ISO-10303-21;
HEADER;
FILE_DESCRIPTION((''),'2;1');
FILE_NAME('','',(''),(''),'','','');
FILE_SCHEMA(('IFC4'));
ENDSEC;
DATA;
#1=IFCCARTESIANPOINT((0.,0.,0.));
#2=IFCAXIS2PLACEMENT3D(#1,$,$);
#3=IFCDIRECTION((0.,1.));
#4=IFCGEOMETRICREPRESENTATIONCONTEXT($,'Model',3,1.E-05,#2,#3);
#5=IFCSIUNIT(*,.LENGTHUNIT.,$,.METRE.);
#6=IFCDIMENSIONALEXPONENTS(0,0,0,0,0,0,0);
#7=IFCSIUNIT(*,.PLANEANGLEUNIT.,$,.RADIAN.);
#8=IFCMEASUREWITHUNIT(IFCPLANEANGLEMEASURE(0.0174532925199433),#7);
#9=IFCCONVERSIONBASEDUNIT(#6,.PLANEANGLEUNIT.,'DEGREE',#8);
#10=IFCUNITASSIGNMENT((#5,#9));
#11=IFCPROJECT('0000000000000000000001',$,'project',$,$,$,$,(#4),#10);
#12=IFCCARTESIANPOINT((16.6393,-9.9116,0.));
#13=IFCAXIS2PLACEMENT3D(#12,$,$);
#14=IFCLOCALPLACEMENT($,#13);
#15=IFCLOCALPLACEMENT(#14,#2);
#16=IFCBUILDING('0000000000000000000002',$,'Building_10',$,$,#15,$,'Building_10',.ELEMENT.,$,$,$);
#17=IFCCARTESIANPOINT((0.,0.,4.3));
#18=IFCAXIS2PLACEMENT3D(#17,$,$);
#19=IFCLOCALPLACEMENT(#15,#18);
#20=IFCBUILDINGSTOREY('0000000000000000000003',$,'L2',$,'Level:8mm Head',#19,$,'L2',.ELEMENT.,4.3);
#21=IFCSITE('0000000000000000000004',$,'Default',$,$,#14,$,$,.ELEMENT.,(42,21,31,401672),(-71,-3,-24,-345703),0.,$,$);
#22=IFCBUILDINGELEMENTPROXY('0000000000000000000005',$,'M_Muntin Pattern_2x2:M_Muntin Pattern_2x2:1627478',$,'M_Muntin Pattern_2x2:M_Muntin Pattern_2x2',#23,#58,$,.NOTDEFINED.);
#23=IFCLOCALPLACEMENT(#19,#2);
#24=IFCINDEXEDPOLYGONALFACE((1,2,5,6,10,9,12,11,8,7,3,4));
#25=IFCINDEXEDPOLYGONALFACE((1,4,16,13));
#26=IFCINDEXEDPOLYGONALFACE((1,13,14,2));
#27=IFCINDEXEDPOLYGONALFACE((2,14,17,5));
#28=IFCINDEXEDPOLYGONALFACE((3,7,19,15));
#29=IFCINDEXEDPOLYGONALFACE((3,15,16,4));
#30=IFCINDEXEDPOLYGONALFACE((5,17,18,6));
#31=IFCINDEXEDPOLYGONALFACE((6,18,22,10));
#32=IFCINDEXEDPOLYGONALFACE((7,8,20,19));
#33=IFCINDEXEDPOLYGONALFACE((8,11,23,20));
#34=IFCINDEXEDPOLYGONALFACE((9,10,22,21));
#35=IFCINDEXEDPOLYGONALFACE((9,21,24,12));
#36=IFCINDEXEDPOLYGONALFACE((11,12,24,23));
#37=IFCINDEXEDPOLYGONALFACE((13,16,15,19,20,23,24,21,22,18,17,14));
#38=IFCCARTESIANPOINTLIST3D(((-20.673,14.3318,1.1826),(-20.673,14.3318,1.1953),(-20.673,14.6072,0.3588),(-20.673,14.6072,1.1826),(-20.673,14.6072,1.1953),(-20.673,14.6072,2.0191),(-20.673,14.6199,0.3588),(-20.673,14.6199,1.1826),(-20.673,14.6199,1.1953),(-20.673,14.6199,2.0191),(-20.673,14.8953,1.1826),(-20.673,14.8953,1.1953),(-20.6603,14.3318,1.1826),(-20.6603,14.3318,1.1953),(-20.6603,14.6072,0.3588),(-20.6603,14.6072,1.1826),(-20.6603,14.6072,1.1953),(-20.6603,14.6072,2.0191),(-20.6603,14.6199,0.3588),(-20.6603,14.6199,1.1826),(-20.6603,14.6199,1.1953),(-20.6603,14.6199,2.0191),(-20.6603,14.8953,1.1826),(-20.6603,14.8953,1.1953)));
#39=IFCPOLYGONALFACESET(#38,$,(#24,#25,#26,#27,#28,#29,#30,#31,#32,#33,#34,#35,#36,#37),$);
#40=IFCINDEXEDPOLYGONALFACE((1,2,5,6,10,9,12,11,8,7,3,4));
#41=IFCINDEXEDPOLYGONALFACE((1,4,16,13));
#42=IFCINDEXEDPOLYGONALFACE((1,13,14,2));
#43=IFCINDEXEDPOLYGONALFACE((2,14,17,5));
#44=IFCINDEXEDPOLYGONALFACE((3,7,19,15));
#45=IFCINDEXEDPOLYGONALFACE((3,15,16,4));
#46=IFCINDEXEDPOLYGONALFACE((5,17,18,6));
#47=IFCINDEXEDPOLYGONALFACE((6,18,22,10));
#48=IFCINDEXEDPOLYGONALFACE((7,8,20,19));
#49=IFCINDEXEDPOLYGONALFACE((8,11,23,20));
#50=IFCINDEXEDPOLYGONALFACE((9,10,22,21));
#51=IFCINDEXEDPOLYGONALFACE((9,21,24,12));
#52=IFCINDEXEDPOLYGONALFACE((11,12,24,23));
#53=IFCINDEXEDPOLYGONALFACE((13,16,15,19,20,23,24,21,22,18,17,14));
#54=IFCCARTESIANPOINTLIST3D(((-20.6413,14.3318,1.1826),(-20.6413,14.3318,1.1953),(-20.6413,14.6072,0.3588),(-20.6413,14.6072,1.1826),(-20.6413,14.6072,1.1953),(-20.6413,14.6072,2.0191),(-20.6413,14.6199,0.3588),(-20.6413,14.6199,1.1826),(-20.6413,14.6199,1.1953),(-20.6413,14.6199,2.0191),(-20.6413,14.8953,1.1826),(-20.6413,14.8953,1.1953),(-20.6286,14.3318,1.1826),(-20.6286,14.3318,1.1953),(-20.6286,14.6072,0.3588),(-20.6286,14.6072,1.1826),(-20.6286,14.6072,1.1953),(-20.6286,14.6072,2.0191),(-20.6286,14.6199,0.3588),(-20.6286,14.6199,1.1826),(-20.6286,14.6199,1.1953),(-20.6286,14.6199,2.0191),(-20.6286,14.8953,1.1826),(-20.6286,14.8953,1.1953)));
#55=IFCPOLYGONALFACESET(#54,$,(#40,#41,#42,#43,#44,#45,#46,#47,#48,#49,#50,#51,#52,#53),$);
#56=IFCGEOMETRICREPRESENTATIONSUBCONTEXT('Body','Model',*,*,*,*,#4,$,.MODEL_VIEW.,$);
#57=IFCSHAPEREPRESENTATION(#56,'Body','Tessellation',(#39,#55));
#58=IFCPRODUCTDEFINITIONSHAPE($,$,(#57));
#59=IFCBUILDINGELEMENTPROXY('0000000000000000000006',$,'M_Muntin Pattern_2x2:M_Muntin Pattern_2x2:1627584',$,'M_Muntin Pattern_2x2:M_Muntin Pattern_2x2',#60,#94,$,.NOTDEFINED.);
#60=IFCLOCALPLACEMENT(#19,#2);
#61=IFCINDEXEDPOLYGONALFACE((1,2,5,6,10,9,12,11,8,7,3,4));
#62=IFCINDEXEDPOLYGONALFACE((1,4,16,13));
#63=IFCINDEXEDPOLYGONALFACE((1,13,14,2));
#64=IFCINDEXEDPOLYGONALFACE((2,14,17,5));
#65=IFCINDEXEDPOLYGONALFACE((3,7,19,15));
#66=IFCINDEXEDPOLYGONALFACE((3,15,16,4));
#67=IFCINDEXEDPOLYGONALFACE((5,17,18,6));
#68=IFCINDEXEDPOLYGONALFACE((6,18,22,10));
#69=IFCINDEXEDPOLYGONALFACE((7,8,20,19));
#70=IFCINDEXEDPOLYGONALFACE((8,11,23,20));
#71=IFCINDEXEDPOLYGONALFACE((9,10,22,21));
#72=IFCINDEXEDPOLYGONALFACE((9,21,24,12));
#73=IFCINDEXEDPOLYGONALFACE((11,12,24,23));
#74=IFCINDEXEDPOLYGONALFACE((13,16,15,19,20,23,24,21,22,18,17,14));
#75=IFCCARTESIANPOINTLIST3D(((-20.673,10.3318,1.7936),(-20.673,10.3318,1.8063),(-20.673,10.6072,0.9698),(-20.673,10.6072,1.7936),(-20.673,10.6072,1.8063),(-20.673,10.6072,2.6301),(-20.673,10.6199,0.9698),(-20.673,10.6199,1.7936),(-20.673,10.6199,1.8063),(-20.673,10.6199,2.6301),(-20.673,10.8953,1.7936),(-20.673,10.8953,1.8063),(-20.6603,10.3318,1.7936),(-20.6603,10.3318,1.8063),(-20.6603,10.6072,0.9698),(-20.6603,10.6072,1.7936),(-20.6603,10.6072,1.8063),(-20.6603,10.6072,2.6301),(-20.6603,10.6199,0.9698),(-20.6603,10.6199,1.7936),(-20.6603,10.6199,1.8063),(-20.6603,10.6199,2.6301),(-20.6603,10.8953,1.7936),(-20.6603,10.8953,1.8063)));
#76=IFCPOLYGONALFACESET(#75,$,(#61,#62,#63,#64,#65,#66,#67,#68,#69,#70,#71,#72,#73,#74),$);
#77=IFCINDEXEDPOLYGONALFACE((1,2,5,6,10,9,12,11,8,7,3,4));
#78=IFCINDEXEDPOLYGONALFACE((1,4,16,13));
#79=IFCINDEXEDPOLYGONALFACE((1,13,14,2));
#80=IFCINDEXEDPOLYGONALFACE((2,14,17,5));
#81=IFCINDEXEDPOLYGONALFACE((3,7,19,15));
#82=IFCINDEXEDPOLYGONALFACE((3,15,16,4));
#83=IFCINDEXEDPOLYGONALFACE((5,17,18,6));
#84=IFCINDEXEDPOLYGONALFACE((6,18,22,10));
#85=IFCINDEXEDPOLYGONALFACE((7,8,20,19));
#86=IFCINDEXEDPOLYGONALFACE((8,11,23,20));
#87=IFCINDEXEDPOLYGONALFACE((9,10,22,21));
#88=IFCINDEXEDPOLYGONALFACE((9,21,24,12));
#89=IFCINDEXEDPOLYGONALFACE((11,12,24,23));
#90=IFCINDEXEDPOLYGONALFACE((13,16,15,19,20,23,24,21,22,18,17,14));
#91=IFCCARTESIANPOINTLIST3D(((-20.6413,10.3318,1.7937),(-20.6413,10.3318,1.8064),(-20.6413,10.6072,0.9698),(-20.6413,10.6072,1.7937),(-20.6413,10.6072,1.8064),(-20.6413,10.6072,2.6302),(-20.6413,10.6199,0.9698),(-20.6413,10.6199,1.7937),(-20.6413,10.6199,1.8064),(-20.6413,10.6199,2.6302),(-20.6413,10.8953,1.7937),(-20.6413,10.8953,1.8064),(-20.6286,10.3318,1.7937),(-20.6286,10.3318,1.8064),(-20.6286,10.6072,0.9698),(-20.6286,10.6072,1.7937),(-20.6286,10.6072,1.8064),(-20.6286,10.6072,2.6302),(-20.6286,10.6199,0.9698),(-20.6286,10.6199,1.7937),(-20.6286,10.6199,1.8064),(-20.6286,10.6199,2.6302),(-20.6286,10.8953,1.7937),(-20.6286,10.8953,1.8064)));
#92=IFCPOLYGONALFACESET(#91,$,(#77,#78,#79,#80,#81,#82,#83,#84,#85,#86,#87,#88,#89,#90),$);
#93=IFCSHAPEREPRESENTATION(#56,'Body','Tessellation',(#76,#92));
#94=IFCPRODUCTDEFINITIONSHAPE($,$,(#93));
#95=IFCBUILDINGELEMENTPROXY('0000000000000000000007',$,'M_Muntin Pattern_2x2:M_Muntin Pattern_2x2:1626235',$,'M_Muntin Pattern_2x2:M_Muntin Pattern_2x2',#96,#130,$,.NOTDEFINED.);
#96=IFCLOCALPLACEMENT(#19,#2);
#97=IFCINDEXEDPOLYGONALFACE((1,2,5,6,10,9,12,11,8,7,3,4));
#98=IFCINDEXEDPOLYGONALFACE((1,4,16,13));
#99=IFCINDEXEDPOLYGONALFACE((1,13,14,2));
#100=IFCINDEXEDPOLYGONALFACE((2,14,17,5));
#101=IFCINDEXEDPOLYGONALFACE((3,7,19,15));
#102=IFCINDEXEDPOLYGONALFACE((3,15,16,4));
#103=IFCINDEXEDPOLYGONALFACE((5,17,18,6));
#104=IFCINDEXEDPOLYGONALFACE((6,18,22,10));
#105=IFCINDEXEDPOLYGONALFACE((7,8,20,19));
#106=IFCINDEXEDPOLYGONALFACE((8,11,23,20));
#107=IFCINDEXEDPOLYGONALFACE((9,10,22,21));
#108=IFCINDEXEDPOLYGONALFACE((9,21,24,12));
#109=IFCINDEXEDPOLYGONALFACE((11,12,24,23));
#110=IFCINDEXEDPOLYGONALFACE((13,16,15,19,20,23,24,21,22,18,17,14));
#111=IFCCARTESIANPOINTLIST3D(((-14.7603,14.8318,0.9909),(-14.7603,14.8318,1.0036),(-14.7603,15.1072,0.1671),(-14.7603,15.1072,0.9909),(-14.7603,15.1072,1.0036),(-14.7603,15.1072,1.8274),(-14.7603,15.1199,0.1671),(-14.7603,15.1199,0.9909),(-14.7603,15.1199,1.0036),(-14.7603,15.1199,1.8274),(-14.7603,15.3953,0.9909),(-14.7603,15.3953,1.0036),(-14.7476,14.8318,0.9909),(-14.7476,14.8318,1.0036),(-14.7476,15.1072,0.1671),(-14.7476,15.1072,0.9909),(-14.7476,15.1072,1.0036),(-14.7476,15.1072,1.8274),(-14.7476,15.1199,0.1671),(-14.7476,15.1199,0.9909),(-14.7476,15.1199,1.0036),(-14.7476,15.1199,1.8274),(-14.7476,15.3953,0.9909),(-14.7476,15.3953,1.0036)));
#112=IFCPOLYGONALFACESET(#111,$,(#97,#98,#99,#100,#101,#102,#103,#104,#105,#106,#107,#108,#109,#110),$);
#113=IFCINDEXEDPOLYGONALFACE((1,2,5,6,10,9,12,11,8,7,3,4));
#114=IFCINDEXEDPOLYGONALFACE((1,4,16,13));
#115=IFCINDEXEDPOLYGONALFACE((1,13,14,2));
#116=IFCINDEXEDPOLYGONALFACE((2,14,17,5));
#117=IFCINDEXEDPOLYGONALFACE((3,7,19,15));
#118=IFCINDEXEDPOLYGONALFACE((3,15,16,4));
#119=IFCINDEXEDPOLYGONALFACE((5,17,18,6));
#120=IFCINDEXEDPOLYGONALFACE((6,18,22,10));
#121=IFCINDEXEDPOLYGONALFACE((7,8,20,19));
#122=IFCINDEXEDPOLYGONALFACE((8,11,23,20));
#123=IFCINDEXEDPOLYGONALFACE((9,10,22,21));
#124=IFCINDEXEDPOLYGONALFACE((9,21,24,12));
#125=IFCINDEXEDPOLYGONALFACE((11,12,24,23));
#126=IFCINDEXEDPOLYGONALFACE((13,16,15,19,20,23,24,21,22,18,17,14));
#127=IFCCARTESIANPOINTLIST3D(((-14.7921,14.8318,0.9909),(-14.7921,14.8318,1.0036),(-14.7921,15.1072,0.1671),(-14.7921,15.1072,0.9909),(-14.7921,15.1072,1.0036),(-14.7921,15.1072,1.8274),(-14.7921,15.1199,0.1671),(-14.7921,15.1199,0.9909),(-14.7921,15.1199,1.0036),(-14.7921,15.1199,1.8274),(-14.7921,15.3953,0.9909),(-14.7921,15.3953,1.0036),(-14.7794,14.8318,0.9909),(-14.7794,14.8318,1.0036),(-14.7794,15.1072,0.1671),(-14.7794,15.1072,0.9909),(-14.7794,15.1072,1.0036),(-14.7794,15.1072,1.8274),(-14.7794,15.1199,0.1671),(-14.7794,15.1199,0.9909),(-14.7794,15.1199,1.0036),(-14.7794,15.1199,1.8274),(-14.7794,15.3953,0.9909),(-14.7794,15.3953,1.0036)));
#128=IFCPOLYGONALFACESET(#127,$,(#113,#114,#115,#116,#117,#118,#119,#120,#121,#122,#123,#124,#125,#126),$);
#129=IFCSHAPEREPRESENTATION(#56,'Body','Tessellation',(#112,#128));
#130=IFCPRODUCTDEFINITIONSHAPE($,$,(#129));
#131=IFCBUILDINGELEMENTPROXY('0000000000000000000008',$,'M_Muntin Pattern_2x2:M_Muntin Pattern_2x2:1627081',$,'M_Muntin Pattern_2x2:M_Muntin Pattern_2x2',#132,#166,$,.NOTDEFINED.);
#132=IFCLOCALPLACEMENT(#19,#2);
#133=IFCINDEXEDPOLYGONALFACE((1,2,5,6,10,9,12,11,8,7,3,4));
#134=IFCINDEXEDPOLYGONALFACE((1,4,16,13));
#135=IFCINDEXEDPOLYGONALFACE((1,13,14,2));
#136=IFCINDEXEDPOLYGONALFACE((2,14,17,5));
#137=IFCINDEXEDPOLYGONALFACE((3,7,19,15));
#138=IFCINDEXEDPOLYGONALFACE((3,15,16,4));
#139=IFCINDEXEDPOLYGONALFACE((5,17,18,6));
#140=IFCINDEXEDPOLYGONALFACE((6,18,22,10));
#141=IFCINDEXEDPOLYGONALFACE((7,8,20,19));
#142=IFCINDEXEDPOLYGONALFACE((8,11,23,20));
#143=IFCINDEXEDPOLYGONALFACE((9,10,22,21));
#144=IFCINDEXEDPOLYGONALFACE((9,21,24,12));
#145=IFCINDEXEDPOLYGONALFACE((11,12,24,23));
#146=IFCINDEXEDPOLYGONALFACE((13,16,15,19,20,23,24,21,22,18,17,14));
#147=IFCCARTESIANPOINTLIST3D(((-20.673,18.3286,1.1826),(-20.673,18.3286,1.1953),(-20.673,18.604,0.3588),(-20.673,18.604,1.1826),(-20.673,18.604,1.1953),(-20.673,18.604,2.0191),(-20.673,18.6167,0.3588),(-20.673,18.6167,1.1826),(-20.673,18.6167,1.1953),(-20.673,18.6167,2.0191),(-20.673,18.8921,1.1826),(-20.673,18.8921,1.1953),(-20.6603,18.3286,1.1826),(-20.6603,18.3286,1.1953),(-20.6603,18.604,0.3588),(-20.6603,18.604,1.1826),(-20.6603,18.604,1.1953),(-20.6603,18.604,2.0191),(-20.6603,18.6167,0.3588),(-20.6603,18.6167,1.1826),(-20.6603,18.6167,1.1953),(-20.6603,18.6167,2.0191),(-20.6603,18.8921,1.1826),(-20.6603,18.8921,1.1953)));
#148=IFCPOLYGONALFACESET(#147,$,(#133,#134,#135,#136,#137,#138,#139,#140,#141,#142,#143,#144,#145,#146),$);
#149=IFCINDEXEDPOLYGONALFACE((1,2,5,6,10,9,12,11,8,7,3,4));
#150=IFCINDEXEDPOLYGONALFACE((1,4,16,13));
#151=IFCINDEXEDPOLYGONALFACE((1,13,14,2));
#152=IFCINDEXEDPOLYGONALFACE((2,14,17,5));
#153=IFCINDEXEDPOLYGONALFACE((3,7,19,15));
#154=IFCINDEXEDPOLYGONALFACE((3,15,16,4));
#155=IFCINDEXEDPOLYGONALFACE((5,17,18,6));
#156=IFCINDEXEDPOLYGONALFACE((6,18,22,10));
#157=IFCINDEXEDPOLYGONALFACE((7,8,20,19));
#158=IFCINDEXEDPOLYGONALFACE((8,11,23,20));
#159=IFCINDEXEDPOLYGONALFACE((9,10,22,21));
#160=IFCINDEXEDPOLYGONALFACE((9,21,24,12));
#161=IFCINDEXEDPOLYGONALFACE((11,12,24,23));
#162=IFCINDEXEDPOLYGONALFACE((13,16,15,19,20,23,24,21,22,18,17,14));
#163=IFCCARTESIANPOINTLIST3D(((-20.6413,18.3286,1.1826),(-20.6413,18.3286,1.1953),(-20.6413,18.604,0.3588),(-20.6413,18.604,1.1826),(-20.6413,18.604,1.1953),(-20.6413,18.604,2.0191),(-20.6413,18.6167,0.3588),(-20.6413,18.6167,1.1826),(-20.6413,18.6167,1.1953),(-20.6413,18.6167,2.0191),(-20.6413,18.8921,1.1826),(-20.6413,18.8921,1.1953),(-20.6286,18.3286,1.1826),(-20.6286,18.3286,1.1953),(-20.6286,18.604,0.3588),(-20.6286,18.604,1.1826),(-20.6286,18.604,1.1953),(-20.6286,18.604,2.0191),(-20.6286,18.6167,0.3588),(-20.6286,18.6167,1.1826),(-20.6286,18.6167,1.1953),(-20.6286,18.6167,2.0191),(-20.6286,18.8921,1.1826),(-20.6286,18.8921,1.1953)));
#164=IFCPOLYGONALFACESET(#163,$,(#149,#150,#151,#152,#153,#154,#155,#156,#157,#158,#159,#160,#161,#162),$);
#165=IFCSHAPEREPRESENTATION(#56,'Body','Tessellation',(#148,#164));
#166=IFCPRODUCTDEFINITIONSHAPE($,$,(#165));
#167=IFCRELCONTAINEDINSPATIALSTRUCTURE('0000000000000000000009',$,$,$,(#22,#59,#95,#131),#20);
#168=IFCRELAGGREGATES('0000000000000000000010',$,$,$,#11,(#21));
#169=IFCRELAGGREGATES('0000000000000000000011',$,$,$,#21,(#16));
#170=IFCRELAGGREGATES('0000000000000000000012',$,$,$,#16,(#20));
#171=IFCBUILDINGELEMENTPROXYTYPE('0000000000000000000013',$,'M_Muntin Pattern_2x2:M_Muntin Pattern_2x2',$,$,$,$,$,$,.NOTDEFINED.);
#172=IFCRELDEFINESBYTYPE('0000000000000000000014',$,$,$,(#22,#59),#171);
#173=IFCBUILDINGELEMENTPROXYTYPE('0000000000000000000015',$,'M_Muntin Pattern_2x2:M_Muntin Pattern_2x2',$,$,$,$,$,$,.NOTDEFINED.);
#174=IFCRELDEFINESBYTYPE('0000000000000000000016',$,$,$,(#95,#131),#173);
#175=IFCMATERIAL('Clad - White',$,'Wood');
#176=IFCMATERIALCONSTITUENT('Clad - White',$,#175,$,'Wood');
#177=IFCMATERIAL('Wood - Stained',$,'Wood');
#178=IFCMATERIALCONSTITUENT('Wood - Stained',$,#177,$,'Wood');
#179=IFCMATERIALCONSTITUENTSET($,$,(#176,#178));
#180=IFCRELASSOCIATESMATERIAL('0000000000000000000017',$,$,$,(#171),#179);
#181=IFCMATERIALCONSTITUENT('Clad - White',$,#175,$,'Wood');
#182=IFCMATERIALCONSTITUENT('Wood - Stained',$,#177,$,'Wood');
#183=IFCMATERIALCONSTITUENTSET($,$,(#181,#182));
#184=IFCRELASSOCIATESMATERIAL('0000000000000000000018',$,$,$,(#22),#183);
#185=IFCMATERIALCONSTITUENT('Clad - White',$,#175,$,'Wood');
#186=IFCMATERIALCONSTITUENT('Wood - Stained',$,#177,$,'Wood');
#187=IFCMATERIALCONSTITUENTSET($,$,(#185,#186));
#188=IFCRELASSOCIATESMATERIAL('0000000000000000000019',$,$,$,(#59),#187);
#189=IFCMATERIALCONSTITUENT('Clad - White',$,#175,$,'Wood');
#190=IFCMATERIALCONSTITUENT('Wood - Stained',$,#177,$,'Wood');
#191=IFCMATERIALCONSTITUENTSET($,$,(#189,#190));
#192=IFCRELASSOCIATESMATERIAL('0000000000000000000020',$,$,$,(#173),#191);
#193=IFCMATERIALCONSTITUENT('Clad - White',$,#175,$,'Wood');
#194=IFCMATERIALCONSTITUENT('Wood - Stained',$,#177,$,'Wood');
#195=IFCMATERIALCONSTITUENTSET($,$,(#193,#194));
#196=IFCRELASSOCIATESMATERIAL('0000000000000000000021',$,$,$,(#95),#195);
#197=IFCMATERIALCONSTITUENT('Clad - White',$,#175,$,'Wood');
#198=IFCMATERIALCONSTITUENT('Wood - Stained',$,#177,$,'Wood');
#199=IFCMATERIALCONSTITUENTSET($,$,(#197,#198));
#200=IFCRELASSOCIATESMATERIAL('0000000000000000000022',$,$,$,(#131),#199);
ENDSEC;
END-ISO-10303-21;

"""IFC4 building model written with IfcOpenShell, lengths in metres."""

from ifc_helpers import new_model, entity, si_unit, converted_unit, direction, frame, origin, place, context, subcontext, project, spatial, indexed_curve, outline, extrude, source, transform, mapped, material, constituent, constituent_set, type_object, type_shapes, element, save


model = new_model("IFC4")

# Units and contexts
model_context = context("Model", 3, precision=1e-05, world=origin(), true_north=direction((0.0, 1.0)))
body_context = subcontext(model_context, "Body", "Model", "MODEL_VIEW")
ifc_project = project(units=[si_unit("LENGTHUNIT", "METRE"), converted_unit("PLANEANGLEUNIT", "DEGREE", entity("IfcPlaneAngleMeasure", 0.0174532925199433), si_unit("PLANEANGLEUNIT", "RADIAN"), dimensions=[0, 0, 0, 0, 0, 0, 0])], contexts=[model_context])

# Site, building, storey
site_placement = place(None, frame((16.6393, -9.9116, 0.0)))
site = spatial("IfcSite", under=ifc_project, at=site_placement, Name="Default", CompositionType="ELEMENT", RefLatitude=(42, 21, 31, 401672), RefLongitude=(-71, -3, -24, -345703), RefElevation=0.0)
building_placement = place(site_placement, origin())
building = spatial("IfcBuilding", under=site, at=building_placement, Name="Building_10", LongName="Building_10", CompositionType="ELEMENT")
storey_placement = place(building_placement, frame((0.0, 0.0, 4.3)))
storey = spatial("IfcBuildingStorey", under=building, at=storey_placement, Name="L2", ObjectType="Level:8mm Head", LongName="L2", CompositionType="ELEMENT", Elevation=4.3)

# Building element proxies
ifc_material_1 = material(Name="Clad - White", Category="Wood")
ifc_material_2 = material(Name="Wood - Stained", Category="Wood")
ifc_constituent_1 = constituent(ifc_material_1, Name="Clad - White", Category="Wood")
ifc_constituent_2 = constituent(ifc_material_2, Name="Wood - Stained", Category="Wood")
ifc_constituent_set_1 = constituent_set(constituents=[ifc_constituent_1, ifc_constituent_2])
building_element_proxy_type_1 = type_object("IfcBuildingElementProxyType", Name="M_Muntin Pattern_2x2:M_Muntin Pattern_2x2", PredefinedType="NOTDEFINED", material=ifc_constituent_set_1)
shared_shape_1 = source(origin(), body_context, "Body", "SweptSolid", [
    extrude(outline(indexed_curve([(0.0064, -0.0064), (0.8301, -0.0064), (0.8301, 0.0063), (0.0064, 0.0063), (0.0064, 0.2817), (-0.0063, 0.2817), (-0.0063, 0.0063), (-0.8302, 0.0063), (-0.8302, -0.0064), (-0.0063, -0.0064), (-0.0063, -0.2817), (0.0064, -0.2817), (0.0064, -0.0064)], self_intersect=False)), frame((0.0, 0.0095, 0.8301), z_axis=(0.0, 1.0, 0.0), x_axis=(0.0, 0.0, 1.0)), (0.0, 0.0, 1.0), 0.0127),
    extrude(outline(indexed_curve([(0.0064, -0.0064), (0.8302, -0.0064), (0.8302, 0.0063), (0.0064, 0.0063), (0.0064, 0.2817), (-0.0063, 0.2817), (-0.0063, 0.0063), (-0.8302, 0.0063), (-0.8302, -0.0064), (-0.0063, -0.0064), (-0.0063, -0.2817), (0.0064, -0.2817), (0.0064, -0.0064)], self_intersect=False)), frame((0.0, -0.0222, 0.8302), z_axis=(0.0, 1.0, 0.0), x_axis=(0.0, 0.0, 1.0)), (0.0, 0.0, 1.0), 0.0127),
])
type_shapes(building_element_proxy_type_1, [shared_shape_1])
ifc_constituent_3 = constituent(ifc_material_1, Name="Clad - White", Category="Wood")
ifc_constituent_4 = constituent(ifc_material_2, Name="Wood - Stained", Category="Wood")
ifc_constituent_set_2 = constituent_set(constituents=[ifc_constituent_3, ifc_constituent_4])
proxy_1_placement = place(storey_placement, frame((-20.6508, 14.6136, 0.3588), z_axis=(0.0, 0.0, 1.0), x_axis=(0.0, 1.0, 0.0)))
element("IfcBuildingElementProxy", 1, at=proxy_1_placement, inside=storey, type_object=building_element_proxy_type_1, material=ifc_constituent_set_2, Name="M_Muntin Pattern_2x2:M_Muntin Pattern_2x2:1627478", ObjectType="M_Muntin Pattern_2x2:M_Muntin Pattern_2x2", PredefinedType="NOTDEFINED", context=body_context, shape_type="MappedRepresentation", body=[
    mapped(shared_shape_1, transform((0.0, 0.0, 0.0), scale=1.0)),
])
ifc_constituent_5 = constituent(ifc_material_1, Name="Clad - White", Category="Wood")
ifc_constituent_6 = constituent(ifc_material_2, Name="Wood - Stained", Category="Wood")
ifc_constituent_set_3 = constituent_set(constituents=[ifc_constituent_5, ifc_constituent_6])
proxy_2_placement = place(storey_placement, frame((-20.6508, 10.6136, 0.9698), z_axis=(0.0, 0.0, 1.0), x_axis=(0.0, 1.0, 0.0)))
element("IfcBuildingElementProxy", 2, at=proxy_2_placement, inside=storey, type_object=building_element_proxy_type_1, material=ifc_constituent_set_3, Name="M_Muntin Pattern_2x2:M_Muntin Pattern_2x2:1627584", ObjectType="M_Muntin Pattern_2x2:M_Muntin Pattern_2x2", PredefinedType="NOTDEFINED", context=body_context, shape_type="MappedRepresentation", body=[
    mapped(shared_shape_1, transform((0.0, 0.0, 0.0), scale=1.0)),
])
ifc_constituent_7 = constituent(ifc_material_1, Name="Clad - White", Category="Wood")
ifc_constituent_8 = constituent(ifc_material_2, Name="Wood - Stained", Category="Wood")
ifc_constituent_set_4 = constituent_set(constituents=[ifc_constituent_7, ifc_constituent_8])
ifc_constituent_9 = constituent(ifc_material_1, Name="Clad - White", Category="Wood")
ifc_constituent_10 = constituent(ifc_material_2, Name="Wood - Stained", Category="Wood")
ifc_constituent_set_5 = constituent_set(constituents=[ifc_constituent_9, ifc_constituent_10])
building_element_proxy_type_2 = type_object("IfcBuildingElementProxyType", Name="M_Muntin Pattern_2x2:M_Muntin Pattern_2x2", PredefinedType="NOTDEFINED", material=ifc_constituent_set_5)
shared_shape_2 = source(origin(), body_context, "Body", "SweptSolid", [
    extrude(outline(indexed_curve([(0.0064, -0.0064), (0.8301, -0.0064), (0.8301, 0.0063), (0.0064, 0.0063), (0.0064, 0.2817), (-0.0063, 0.2817), (-0.0063, 0.0063), (-0.8302, 0.0063), (-0.8302, -0.0064), (-0.0063, -0.0064), (-0.0063, -0.2817), (0.0064, -0.2817), (0.0064, -0.0064)], self_intersect=False)), frame((0.0, -0.0222, 0.8301), z_axis=(0.0, 1.0, 0.0), x_axis=(0.0, 0.0, 1.0)), (0.0, 0.0, 1.0), 0.0127),
    extrude(outline(indexed_curve([(0.0064, -0.0064), (0.8302, -0.0064), (0.8302, 0.0063), (0.0064, 0.0063), (0.0064, 0.2817), (-0.0063, 0.2817), (-0.0063, 0.0063), (-0.8302, 0.0063), (-0.8302, -0.0064), (-0.0063, -0.0064), (-0.0063, -0.2817), (0.0064, -0.2817), (0.0064, -0.0064)], self_intersect=False)), frame((0.0, 0.0095, 0.8302), z_axis=(0.0, 1.0, 0.0), x_axis=(0.0, 0.0, 1.0)), (0.0, 0.0, 1.0), 0.0127),
])
type_shapes(building_element_proxy_type_2, [shared_shape_2])
proxy_3_placement = place(storey_placement, frame((-14.7698, 15.1136, 0.1671), z_axis=(0.0, 0.0, 1.0), x_axis=(0.0, 1.0, 0.0)))
element("IfcBuildingElementProxy", 3, at=proxy_3_placement, inside=storey, type_object=building_element_proxy_type_2, material=ifc_constituent_set_4, Name="M_Muntin Pattern_2x2:M_Muntin Pattern_2x2:1626235", ObjectType="M_Muntin Pattern_2x2:M_Muntin Pattern_2x2", PredefinedType="NOTDEFINED", context=body_context, shape_type="MappedRepresentation", body=[
    mapped(shared_shape_2, transform((0.0, 0.0, 0.0), scale=1.0)),
])
ifc_constituent_11 = constituent(ifc_material_1, Name="Clad - White", Category="Wood")
ifc_constituent_12 = constituent(ifc_material_2, Name="Wood - Stained", Category="Wood")
ifc_constituent_set_6 = constituent_set(constituents=[ifc_constituent_11, ifc_constituent_12])
proxy_4_placement = place(storey_placement, frame((-20.6508, 18.6104, 0.3588), z_axis=(0.0, 0.0, 1.0), x_axis=(0.0, -1.0, 0.0)))
element("IfcBuildingElementProxy", 4, at=proxy_4_placement, inside=storey, type_object=building_element_proxy_type_2, material=ifc_constituent_set_6, Name="M_Muntin Pattern_2x2:M_Muntin Pattern_2x2:1627081", ObjectType="M_Muntin Pattern_2x2:M_Muntin Pattern_2x2", PredefinedType="NOTDEFINED", context=body_context, shape_type="MappedRepresentation", body=[
    mapped(shared_shape_2, transform((0.0, 0.0, 0.0), scale=1.0)),
])

save(model, "model.ifc")
